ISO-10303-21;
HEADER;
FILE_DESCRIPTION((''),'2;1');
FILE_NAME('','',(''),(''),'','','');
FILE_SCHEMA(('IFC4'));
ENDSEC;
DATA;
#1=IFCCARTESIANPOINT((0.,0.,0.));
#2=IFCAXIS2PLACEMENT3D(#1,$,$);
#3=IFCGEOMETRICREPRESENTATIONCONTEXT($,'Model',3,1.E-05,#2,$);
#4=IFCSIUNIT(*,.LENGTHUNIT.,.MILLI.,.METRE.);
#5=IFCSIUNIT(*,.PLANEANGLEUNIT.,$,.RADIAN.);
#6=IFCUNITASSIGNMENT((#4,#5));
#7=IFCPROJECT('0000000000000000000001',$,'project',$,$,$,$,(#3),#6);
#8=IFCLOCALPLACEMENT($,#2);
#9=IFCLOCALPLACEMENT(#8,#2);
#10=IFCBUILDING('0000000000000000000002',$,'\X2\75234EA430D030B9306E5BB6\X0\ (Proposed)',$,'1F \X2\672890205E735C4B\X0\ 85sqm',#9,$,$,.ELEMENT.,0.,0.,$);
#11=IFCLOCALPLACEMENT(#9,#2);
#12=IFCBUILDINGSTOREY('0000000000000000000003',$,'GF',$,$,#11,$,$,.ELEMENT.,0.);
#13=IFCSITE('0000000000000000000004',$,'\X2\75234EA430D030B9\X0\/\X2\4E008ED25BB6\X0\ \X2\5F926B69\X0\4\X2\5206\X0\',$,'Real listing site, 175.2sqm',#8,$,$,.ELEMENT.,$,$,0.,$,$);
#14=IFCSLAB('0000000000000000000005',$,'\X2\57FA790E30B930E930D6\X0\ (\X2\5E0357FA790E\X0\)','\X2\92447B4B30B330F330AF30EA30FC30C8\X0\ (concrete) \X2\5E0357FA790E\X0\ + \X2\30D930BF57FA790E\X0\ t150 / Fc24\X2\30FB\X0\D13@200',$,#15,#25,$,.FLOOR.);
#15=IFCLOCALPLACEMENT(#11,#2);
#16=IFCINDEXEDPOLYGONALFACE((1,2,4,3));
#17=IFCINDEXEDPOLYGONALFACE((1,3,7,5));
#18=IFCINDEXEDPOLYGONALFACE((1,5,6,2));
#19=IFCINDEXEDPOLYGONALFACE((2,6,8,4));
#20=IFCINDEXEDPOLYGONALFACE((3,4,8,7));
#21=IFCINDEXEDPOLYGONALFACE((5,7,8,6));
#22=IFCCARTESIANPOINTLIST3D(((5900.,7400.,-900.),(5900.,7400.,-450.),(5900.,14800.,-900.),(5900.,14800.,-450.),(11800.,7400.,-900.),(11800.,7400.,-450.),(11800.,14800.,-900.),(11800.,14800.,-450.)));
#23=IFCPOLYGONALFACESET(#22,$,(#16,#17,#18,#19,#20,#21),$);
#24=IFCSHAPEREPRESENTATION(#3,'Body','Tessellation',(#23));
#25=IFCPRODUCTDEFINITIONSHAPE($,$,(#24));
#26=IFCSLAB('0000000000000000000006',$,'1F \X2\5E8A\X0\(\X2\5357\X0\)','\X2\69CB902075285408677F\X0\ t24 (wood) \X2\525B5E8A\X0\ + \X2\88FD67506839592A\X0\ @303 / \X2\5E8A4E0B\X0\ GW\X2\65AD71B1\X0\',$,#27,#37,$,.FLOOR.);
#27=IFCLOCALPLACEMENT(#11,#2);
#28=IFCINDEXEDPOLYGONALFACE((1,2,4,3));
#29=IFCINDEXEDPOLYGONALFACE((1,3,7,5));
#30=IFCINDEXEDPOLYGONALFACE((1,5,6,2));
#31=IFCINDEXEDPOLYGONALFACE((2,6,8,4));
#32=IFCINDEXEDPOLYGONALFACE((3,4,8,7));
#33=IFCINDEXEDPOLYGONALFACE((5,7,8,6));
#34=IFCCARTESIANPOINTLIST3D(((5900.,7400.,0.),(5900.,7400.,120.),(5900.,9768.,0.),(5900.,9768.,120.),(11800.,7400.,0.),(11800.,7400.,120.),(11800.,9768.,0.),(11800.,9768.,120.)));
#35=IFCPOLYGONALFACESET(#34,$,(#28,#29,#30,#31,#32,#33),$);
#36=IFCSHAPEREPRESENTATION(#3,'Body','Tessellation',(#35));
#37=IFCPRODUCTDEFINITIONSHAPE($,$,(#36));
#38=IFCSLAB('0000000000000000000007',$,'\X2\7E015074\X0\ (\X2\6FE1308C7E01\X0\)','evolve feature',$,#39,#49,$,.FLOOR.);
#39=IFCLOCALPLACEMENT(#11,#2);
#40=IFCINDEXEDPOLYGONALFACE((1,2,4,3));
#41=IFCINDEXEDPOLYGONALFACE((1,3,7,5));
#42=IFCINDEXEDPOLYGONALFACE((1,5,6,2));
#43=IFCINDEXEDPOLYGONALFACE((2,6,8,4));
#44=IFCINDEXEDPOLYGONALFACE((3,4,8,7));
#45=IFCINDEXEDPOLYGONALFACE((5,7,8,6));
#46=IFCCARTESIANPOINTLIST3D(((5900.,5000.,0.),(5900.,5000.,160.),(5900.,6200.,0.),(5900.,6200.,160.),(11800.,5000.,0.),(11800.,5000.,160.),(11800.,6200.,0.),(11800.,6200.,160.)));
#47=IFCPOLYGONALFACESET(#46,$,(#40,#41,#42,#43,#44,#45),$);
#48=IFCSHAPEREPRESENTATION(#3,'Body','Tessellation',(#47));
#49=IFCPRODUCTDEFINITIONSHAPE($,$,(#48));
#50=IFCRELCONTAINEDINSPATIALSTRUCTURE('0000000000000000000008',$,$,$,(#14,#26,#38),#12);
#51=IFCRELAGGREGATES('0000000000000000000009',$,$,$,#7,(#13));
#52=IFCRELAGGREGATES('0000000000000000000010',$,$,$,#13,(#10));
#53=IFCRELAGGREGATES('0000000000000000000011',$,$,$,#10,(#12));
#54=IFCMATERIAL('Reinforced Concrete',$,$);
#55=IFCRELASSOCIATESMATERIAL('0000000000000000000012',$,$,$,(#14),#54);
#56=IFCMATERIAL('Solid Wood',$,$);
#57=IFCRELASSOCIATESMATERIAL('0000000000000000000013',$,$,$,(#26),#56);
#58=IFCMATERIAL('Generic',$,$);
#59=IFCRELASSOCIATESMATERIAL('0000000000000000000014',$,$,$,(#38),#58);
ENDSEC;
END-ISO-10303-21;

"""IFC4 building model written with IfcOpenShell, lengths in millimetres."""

from ifc_helpers import new_model, si_unit, frame, frame_2d, origin, place, context, project, spatial, rectangle, extrude, material, element, save


model = new_model("IFC4")

# Units and contexts
model_context = context("Model", 3, precision=1e-05, world=origin())
ifc_project = project(units=[si_unit("LENGTHUNIT", "METRE", prefix="MILLI"), si_unit("PLANEANGLEUNIT", "RADIAN")], contexts=[model_context])

# Site, building, storey
site_placement = place(None, origin())
site = spatial("IfcSite", under=ifc_project, at=site_placement, Name="産交バス/一軒家 徒歩4分", ObjectType="Real listing site, 175.2sqm", CompositionType="ELEMENT", RefElevation=0.0)
building_placement = place(site_placement, origin())
building = spatial("IfcBuilding", under=site, at=building_placement, Name="産交バスの家 (Proposed)", ObjectType="1F 木造平屋 85sqm", CompositionType="ELEMENT", ElevationOfRefHeight=0.0, ElevationOfTerrain=0.0)
storey_placement = place(building_placement, origin())
storey = spatial("IfcBuildingStorey", under=building, at=storey_placement, Name="GF", CompositionType="ELEMENT", Elevation=0.0)

# Slabs
ifc_material_1 = material(Name="Reinforced Concrete")
slab_1_placement = place(storey_placement, frame((2950.0, 3700.0, -450.0)))
element("IfcSlab", 1, at=slab_1_placement, inside=storey, material=ifc_material_1, Name="基礎スラブ (布基礎)", Description="鉄筋コンクリート (concrete) 布基礎 + ベタ基礎 t150 / Fc24・D13@200", PredefinedType="FLOOR", context=model_context, shape_type="SweptSolid", body=[
    extrude(rectangle(XDim=5900.0, YDim=7400.0, at=frame_2d((2950.0, 3700.0))), frame((2950.0, 3700.0, -450.0)), (0.0, 0.0, 1.0), 450.0),
])
ifc_material_2 = material(Name="Solid Wood")
slab_2_placement = place(storey_placement, frame((2950.0, 3700.0, 0.0)))
element("IfcSlab", 2, at=slab_2_placement, inside=storey, material=ifc_material_2, Name="1F 床(南)", Description="構造用合板 t24 (wood) 剛床 + 製材根太 @303 / 床下 GW断熱", PredefinedType="FLOOR", context=model_context, shape_type="SweptSolid", body=[
    extrude(rectangle(XDim=5900.0, YDim=2368.0, at=frame_2d((2950.0, 1184.0))), frame((2950.0, 3700.0, 0.0)), (0.0, 0.0, 1.0), 120.0),
])
ifc_material_3 = material(Name="Generic")
slab_3_placement = place(storey_placement, frame((2950.0, 2500.0, 0.0)))
element("IfcSlab", 3, at=slab_3_placement, inside=storey, material=ifc_material_3, Name="縁側 (濡れ縁)", Description="evolve feature", PredefinedType="FLOOR", context=model_context, shape_type="SweptSolid", body=[
    extrude(rectangle(XDim=5900.0, YDim=1200.0, at=frame_2d((2950.0, 600.0))), frame((2950.0, 2500.0, 0.0)), (0.0, 0.0, 1.0), 160.0),
])

save(model, "model.ifc")
